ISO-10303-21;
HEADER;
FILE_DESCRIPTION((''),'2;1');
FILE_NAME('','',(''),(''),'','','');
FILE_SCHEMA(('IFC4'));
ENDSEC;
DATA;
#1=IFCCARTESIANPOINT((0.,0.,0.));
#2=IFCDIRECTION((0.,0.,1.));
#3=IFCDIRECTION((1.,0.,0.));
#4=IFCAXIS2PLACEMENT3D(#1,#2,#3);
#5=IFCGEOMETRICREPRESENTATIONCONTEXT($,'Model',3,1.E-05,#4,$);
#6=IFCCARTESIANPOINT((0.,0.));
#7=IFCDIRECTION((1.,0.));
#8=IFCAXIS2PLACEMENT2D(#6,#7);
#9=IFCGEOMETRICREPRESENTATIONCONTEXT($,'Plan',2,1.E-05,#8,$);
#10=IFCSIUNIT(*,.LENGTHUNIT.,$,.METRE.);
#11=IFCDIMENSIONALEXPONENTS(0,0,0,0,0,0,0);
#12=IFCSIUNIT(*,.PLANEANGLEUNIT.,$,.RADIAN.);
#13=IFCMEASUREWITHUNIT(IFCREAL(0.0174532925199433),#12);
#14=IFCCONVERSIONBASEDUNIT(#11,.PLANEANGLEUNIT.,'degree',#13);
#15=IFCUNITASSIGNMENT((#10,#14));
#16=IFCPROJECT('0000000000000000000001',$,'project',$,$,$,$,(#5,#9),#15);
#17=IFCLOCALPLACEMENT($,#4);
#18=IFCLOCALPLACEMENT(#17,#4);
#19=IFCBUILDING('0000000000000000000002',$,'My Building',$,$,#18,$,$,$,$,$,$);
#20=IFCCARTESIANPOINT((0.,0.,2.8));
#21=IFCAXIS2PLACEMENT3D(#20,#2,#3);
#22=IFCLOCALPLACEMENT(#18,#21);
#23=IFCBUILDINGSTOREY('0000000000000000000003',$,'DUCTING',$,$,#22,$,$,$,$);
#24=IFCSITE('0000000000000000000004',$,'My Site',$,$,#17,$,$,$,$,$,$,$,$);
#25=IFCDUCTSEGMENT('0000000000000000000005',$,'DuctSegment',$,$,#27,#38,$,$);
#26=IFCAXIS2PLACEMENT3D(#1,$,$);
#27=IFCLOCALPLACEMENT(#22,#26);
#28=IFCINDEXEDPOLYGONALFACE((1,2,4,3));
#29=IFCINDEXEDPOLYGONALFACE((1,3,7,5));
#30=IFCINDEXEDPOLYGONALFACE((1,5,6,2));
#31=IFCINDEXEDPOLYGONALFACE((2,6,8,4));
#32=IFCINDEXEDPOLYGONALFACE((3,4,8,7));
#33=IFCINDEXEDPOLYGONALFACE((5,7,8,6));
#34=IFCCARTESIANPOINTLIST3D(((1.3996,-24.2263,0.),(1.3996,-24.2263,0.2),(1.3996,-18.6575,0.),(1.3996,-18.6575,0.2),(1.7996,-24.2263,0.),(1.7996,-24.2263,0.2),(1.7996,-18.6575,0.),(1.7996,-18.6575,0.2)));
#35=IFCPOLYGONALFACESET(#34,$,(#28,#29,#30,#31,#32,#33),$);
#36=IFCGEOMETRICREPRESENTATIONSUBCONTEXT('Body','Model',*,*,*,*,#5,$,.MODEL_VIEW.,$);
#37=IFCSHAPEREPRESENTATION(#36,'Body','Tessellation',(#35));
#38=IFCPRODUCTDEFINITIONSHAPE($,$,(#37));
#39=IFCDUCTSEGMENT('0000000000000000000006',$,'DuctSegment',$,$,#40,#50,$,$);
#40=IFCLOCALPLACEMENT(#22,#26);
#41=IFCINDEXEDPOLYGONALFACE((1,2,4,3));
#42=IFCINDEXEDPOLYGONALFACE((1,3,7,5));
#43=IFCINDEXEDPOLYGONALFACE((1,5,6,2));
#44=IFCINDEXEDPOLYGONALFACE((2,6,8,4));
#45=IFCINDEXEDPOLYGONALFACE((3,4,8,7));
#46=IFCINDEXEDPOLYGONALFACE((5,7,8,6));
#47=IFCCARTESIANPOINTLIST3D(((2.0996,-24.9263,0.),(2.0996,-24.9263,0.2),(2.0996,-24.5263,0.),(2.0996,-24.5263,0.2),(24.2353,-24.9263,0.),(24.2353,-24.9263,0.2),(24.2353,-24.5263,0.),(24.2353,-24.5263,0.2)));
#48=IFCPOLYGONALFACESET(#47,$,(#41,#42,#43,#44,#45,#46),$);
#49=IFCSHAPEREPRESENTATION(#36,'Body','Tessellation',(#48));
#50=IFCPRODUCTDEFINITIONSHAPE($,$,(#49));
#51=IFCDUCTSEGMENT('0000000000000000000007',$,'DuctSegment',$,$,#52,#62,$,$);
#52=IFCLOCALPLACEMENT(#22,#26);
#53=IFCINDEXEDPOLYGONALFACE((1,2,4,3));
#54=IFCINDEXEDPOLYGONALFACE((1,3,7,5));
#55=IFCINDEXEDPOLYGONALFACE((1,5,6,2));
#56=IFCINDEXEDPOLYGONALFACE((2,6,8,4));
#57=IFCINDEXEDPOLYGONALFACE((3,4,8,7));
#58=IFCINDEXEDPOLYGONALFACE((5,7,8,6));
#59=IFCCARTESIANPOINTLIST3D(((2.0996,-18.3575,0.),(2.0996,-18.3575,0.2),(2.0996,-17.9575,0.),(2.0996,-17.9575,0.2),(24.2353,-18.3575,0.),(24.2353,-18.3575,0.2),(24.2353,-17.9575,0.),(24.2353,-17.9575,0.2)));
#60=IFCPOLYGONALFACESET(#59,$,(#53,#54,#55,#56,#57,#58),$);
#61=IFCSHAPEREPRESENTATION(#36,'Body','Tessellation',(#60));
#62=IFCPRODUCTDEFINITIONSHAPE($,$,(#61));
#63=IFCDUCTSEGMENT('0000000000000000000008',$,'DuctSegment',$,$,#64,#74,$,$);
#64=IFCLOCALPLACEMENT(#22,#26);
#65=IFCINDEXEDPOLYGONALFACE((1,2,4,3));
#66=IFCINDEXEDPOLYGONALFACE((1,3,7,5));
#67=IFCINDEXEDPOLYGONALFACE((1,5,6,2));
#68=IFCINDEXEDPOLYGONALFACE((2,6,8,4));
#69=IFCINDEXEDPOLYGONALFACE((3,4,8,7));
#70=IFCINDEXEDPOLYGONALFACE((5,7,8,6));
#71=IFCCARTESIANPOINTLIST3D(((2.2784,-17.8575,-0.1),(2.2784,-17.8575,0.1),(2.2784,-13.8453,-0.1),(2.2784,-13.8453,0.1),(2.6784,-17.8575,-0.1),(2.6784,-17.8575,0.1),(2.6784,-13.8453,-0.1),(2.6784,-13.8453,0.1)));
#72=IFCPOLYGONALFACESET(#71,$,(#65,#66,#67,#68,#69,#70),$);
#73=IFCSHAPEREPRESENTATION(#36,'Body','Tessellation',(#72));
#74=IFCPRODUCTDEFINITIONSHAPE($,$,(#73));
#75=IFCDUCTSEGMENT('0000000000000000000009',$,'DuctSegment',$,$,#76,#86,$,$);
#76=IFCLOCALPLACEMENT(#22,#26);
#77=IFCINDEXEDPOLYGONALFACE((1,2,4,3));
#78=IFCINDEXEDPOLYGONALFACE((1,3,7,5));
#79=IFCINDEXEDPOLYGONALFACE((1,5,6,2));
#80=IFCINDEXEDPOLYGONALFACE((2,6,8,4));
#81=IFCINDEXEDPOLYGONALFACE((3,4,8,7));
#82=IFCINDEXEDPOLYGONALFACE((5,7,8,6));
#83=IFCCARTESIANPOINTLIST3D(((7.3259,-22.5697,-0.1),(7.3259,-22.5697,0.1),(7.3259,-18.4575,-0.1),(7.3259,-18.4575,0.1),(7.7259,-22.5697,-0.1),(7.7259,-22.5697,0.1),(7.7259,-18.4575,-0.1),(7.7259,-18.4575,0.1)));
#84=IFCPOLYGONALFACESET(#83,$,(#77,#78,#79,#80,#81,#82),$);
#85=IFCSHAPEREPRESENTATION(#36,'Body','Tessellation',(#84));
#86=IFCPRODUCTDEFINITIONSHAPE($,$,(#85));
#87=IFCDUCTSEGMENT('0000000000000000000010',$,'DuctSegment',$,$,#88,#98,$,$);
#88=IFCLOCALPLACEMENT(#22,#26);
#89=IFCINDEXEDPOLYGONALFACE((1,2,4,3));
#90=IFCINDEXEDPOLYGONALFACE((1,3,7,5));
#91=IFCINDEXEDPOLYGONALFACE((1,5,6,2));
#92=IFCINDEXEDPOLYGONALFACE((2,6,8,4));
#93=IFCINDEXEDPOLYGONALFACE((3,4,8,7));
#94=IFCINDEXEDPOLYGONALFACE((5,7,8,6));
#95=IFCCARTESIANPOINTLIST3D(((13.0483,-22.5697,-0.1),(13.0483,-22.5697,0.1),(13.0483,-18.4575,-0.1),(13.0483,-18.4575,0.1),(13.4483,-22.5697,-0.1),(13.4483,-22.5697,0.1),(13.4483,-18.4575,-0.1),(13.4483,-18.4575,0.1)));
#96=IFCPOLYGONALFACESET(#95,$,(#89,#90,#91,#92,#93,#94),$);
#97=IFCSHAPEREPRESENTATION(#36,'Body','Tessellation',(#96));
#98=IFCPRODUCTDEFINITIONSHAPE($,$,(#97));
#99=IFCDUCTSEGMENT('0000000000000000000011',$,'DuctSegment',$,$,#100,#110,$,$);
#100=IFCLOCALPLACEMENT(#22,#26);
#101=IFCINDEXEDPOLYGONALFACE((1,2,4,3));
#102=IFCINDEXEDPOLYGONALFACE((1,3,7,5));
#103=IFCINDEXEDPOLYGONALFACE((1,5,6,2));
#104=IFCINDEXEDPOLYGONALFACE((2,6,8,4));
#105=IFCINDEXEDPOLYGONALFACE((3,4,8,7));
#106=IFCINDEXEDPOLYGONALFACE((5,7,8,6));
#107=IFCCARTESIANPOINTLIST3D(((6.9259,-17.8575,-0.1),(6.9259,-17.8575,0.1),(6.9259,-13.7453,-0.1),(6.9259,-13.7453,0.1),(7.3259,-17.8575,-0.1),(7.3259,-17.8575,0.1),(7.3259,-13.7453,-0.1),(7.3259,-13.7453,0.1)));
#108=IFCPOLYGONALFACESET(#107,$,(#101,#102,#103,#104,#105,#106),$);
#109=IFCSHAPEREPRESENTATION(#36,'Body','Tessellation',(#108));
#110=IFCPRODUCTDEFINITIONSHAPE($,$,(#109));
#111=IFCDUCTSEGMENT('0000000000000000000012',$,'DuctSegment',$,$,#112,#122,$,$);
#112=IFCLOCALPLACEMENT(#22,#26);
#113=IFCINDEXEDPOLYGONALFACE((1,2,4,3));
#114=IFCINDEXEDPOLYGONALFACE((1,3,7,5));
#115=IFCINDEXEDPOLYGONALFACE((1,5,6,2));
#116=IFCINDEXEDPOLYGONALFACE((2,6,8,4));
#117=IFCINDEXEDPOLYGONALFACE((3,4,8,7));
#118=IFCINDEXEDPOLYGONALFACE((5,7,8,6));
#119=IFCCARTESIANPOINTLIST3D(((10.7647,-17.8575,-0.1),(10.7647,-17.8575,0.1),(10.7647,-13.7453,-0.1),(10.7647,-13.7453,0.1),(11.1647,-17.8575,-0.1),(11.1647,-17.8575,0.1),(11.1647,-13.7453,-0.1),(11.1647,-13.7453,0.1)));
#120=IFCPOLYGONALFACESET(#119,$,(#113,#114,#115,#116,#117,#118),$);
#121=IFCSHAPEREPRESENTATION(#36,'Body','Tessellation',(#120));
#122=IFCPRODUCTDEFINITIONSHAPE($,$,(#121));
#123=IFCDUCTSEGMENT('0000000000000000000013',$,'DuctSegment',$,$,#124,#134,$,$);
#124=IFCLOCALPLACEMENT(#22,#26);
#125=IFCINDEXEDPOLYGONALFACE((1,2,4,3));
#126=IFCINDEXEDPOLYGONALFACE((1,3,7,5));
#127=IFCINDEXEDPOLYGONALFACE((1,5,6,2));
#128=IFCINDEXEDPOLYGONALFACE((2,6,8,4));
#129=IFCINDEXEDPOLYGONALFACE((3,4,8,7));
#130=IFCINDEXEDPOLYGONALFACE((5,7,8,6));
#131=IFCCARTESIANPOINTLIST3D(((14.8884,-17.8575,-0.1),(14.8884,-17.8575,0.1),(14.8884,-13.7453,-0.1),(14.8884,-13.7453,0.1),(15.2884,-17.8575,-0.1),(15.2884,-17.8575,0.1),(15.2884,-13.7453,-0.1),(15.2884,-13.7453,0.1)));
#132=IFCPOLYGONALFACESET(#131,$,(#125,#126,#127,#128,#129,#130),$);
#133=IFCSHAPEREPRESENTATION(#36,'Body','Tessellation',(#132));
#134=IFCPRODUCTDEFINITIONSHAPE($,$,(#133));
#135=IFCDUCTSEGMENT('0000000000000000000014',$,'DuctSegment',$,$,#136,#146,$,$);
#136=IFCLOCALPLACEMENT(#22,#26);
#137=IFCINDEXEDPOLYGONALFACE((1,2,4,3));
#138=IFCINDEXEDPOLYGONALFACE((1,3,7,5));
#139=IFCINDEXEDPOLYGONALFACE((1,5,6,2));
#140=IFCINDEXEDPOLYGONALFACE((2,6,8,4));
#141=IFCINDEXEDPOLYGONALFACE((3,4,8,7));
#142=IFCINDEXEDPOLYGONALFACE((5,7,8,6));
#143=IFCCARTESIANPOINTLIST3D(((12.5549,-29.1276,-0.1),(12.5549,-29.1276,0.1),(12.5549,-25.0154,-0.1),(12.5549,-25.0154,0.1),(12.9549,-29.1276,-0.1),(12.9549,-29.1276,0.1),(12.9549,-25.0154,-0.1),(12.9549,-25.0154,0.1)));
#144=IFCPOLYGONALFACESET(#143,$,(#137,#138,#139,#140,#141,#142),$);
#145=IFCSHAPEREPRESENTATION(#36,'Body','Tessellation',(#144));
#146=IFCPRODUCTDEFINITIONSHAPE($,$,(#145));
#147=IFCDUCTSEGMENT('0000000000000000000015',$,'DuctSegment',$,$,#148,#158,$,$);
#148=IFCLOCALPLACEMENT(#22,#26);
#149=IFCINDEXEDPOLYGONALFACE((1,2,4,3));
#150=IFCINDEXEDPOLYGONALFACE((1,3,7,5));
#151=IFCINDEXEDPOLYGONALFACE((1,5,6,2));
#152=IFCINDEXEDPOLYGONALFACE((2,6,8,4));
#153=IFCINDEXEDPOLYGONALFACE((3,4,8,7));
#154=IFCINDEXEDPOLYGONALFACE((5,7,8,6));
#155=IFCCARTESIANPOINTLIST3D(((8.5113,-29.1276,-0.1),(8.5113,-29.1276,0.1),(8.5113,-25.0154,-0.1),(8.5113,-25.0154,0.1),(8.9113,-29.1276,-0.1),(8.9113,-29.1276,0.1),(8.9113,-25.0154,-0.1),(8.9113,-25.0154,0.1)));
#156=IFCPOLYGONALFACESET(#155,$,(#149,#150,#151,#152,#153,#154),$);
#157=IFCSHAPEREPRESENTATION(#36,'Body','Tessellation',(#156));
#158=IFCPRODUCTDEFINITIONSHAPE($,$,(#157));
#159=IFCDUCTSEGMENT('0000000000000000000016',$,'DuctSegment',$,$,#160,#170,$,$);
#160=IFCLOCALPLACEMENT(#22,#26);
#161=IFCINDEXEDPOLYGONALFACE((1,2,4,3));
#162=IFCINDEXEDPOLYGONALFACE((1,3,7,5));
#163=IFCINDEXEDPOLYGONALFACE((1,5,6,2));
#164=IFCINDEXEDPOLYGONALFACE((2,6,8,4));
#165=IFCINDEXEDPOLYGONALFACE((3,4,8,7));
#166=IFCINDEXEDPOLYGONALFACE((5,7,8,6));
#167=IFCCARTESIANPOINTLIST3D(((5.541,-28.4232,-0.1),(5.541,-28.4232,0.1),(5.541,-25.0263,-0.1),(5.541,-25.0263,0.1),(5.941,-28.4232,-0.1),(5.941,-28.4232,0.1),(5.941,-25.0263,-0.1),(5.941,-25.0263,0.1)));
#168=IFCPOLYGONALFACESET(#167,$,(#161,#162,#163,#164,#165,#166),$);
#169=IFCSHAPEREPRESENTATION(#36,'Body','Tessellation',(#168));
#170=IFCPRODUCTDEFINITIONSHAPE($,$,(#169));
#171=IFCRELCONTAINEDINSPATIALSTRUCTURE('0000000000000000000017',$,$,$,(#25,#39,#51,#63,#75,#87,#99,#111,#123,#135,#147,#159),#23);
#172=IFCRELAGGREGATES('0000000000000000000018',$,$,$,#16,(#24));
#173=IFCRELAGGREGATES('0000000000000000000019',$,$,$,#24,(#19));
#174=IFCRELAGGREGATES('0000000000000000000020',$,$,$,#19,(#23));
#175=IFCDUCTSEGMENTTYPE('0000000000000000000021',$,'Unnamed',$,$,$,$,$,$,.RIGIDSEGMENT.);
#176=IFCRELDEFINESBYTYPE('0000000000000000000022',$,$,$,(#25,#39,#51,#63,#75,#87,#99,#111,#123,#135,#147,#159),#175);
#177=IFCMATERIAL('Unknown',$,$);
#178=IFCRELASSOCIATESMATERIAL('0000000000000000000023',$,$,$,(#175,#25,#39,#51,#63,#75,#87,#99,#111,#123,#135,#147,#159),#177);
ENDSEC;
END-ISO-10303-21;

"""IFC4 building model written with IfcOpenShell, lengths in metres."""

from ifc_helpers import new_model, entity, si_unit, converted_unit, frame, origin_with_axes, origin_2d_with_axis, place, context, subcontext, project, spatial, rectangle, extrude, material, material_profile, profile_set, profile_usage, type_object, element, save


model = new_model("IFC4")

# Units and contexts
model_context = context("Model", 3, precision=1e-05, world=origin_with_axes())
plan_context = context("Plan", 2, precision=1e-05, world=origin_2d_with_axis())
body_context = subcontext(model_context, "Body", "Model", "MODEL_VIEW")
ifc_project = project(units=[si_unit("LENGTHUNIT", "METRE"), converted_unit("PLANEANGLEUNIT", "degree", entity("IfcReal", 0.0174532925199433), si_unit("PLANEANGLEUNIT", "RADIAN"), dimensions=[0, 0, 0, 0, 0, 0, 0])], contexts=[model_context, plan_context])

# Site, building, storey
site_placement = place(None, origin_with_axes())
site = spatial("IfcSite", under=ifc_project, at=site_placement, Name="My Site")
building_placement = place(site_placement, origin_with_axes())
building = spatial("IfcBuilding", under=site, at=building_placement, Name="My Building")
storey_placement = place(building_placement, frame((0.0, 0.0, 2.8), z_axis=(0.0, 0.0, 1.0), x_axis=(1.0, 0.0, 0.0)))
storey = spatial("IfcBuildingStorey", under=building, at=storey_placement, Name="DUCTING")

# Duct segments
ifc_material = material(Name="Unknown")
ifc_material_profile_1 = material_profile(ifc_material, rectangle(XDim=0.4, YDim=0.2))
ifc_profile_set_1 = profile_set([ifc_material_profile_1])
ifc_profile_usage_1 = profile_usage(ifc_profile_set_1, cardinal=5)
duct_segment_type = type_object("IfcDuctSegmentType", Name="Unnamed", PredefinedType="RIGIDSEGMENT", material=ifc_profile_set_1)
duct_segment_1_placement = place(storey_placement, frame((1.5996, -18.6575, 0.1), z_axis=(0.0, -1.0, 0.0), x_axis=(1.0, 0.0, 0.0)))
element("IfcDuctSegment", 1, at=duct_segment_1_placement, inside=storey, type_object=duct_segment_type, material=ifc_profile_usage_1, Name="DuctSegment", context=body_context, shape_type="SweptSolid", body=[
    extrude(rectangle(XDim=0.4, YDim=0.2), origin_with_axes(), (0.0, 0.0, 1.0), 5.5688),
])
ifc_profile_usage_2 = profile_usage(ifc_profile_set_1, cardinal=5)
duct_segment_2_placement = place(storey_placement, frame((2.0996, -24.7263, 0.1), z_axis=(1.0, 0.0, 0.0), x_axis=(0.0, 1.0, 0.0)))
element("IfcDuctSegment", 2, at=duct_segment_2_placement, inside=storey, type_object=duct_segment_type, material=ifc_profile_usage_2, Name="DuctSegment", context=body_context, shape_type="SweptSolid", body=[
    extrude(rectangle(XDim=0.4, YDim=0.2), origin_with_axes(), (0.0, 0.0, 1.0), 22.1357),
])
ifc_profile_usage_3 = profile_usage(ifc_profile_set_1, cardinal=5)
duct_segment_3_placement = place(storey_placement, frame((2.0996, -18.1575, 0.1), z_axis=(1.0, 0.0, 0.0), x_axis=(0.0, 1.0, 0.0)))
element("IfcDuctSegment", 3, at=duct_segment_3_placement, inside=storey, type_object=duct_segment_type, material=ifc_profile_usage_3, Name="DuctSegment", context=body_context, shape_type="SweptSolid", body=[
    extrude(rectangle(XDim=0.4, YDim=0.2), origin_with_axes(), (0.0, 0.0, 1.0), 22.1357),
])
ifc_profile_usage_4 = profile_usage(ifc_profile_set_1, cardinal=5)
duct_segment_4_placement = place(storey_placement, frame((2.4784, -17.8575, 0.0), z_axis=(0.0, 1.0, 0.0), x_axis=(-1.0, 0.0, 0.0)))
element("IfcDuctSegment", 4, at=duct_segment_4_placement, inside=storey, type_object=duct_segment_type, material=ifc_profile_usage_4, Name="DuctSegment", context=body_context, shape_type="SweptSolid", body=[
    extrude(rectangle(XDim=0.4, YDim=0.2), origin_with_axes(), (0.0, 0.0, 1.0), 4.0122),
])
ifc_profile_usage_5 = profile_usage(ifc_profile_set_1, cardinal=5)
duct_segment_5_placement = place(storey_placement, frame((7.5259, -18.4575, 0.0), z_axis=(0.0, -1.0, 0.0), x_axis=(1.0, 0.0, 0.0)))
element("IfcDuctSegment", 5, at=duct_segment_5_placement, inside=storey, type_object=duct_segment_type, material=ifc_profile_usage_5, Name="DuctSegment", context=body_context, shape_type="SweptSolid", body=[
    extrude(rectangle(XDim=0.4, YDim=0.2), origin_with_axes(), (0.0, 0.0, 1.0), 4.1122),
])
ifc_profile_usage_6 = profile_usage(ifc_profile_set_1, cardinal=5)
duct_segment_6_placement = place(storey_placement, frame((13.2483, -18.4575, 0.0), z_axis=(0.0, -1.0, 0.0), x_axis=(1.0, 0.0, 0.0)))
element("IfcDuctSegment", 6, at=duct_segment_6_placement, inside=storey, type_object=duct_segment_type, material=ifc_profile_usage_6, Name="DuctSegment", context=body_context, shape_type="SweptSolid", body=[
    extrude(rectangle(XDim=0.4, YDim=0.2), origin_with_axes(), (0.0, 0.0, 1.0), 4.1122),
])
ifc_profile_usage_7 = profile_usage(ifc_profile_set_1, cardinal=5)
duct_segment_7_placement = place(storey_placement, frame((7.1259, -17.8575, 0.0), z_axis=(0.0, 1.0, 0.0), x_axis=(-1.0, 0.0, 0.0)))
element("IfcDuctSegment", 7, at=duct_segment_7_placement, inside=storey, type_object=duct_segment_type, material=ifc_profile_usage_7, Name="DuctSegment", context=body_context, shape_type="SweptSolid", body=[
    extrude(rectangle(XDim=0.4, YDim=0.2), origin_with_axes(), (0.0, 0.0, 1.0), 4.1122),
])
ifc_profile_usage_8 = profile_usage(ifc_profile_set_1, cardinal=5)
duct_segment_8_placement = place(storey_placement, frame((10.9647, -17.8575, 0.0), z_axis=(0.0, 1.0, 0.0), x_axis=(-1.0, 0.0, 0.0)))
element("IfcDuctSegment", 8, at=duct_segment_8_placement, inside=storey, type_object=duct_segment_type, material=ifc_profile_usage_8, Name="DuctSegment", context=body_context, shape_type="SweptSolid", body=[
    extrude(rectangle(XDim=0.4, YDim=0.2), origin_with_axes(), (0.0, 0.0, 1.0), 4.1122),
])
ifc_profile_usage_9 = profile_usage(ifc_profile_set_1, cardinal=5)
duct_segment_9_placement = place(storey_placement, frame((15.0884, -17.8575, 0.0), z_axis=(0.0, 1.0, 0.0), x_axis=(-1.0, 0.0, 0.0)))
element("IfcDuctSegment", 9, at=duct_segment_9_placement, inside=storey, type_object=duct_segment_type, material=ifc_profile_usage_9, Name="DuctSegment", context=body_context, shape_type="SweptSolid", body=[
    extrude(rectangle(XDim=0.4, YDim=0.2), origin_with_axes(), (0.0, 0.0, 1.0), 4.1122),
])
ifc_profile_usage_10 = profile_usage(ifc_profile_set_1, cardinal=5)
duct_segment_10_placement = place(storey_placement, frame((12.7549, -25.0154, 0.0), z_axis=(0.0, -1.0, 0.0), x_axis=(1.0, 0.0, 0.0)))
element("IfcDuctSegment", 10, at=duct_segment_10_placement, inside=storey, type_object=duct_segment_type, material=ifc_profile_usage_10, Name="DuctSegment", context=body_context, shape_type="SweptSolid", body=[
    extrude(rectangle(XDim=0.4, YDim=0.2), origin_with_axes(), (0.0, 0.0, 1.0), 4.1122),
])
ifc_profile_usage_11 = profile_usage(ifc_profile_set_1, cardinal=5)
duct_segment_11_placement = place(storey_placement, frame((8.7113, -25.0154, 0.0), z_axis=(0.0, -1.0, 0.0), x_axis=(1.0, 0.0, 0.0)))
element("IfcDuctSegment", 11, at=duct_segment_11_placement, inside=storey, type_object=duct_segment_type, material=ifc_profile_usage_11, Name="DuctSegment", context=body_context, shape_type="SweptSolid", body=[
    extrude(rectangle(XDim=0.4, YDim=0.2), origin_with_axes(), (0.0, 0.0, 1.0), 4.1122),
])
ifc_profile_usage_12 = profile_usage(ifc_profile_set_1, cardinal=5)
duct_segment_12_placement = place(storey_placement, frame((5.741, -25.0263, 0.0), z_axis=(0.0, -1.0, 0.0), x_axis=(1.0, 0.0, 0.0)))
element("IfcDuctSegment", 12, at=duct_segment_12_placement, inside=storey, type_object=duct_segment_type, material=ifc_profile_usage_12, Name="DuctSegment", context=body_context, shape_type="SweptSolid", body=[
    extrude(rectangle(XDim=0.4, YDim=0.2), origin_with_axes(), (0.0, 0.0, 1.0), 3.3969),
])

save(model, "model.ifc")
